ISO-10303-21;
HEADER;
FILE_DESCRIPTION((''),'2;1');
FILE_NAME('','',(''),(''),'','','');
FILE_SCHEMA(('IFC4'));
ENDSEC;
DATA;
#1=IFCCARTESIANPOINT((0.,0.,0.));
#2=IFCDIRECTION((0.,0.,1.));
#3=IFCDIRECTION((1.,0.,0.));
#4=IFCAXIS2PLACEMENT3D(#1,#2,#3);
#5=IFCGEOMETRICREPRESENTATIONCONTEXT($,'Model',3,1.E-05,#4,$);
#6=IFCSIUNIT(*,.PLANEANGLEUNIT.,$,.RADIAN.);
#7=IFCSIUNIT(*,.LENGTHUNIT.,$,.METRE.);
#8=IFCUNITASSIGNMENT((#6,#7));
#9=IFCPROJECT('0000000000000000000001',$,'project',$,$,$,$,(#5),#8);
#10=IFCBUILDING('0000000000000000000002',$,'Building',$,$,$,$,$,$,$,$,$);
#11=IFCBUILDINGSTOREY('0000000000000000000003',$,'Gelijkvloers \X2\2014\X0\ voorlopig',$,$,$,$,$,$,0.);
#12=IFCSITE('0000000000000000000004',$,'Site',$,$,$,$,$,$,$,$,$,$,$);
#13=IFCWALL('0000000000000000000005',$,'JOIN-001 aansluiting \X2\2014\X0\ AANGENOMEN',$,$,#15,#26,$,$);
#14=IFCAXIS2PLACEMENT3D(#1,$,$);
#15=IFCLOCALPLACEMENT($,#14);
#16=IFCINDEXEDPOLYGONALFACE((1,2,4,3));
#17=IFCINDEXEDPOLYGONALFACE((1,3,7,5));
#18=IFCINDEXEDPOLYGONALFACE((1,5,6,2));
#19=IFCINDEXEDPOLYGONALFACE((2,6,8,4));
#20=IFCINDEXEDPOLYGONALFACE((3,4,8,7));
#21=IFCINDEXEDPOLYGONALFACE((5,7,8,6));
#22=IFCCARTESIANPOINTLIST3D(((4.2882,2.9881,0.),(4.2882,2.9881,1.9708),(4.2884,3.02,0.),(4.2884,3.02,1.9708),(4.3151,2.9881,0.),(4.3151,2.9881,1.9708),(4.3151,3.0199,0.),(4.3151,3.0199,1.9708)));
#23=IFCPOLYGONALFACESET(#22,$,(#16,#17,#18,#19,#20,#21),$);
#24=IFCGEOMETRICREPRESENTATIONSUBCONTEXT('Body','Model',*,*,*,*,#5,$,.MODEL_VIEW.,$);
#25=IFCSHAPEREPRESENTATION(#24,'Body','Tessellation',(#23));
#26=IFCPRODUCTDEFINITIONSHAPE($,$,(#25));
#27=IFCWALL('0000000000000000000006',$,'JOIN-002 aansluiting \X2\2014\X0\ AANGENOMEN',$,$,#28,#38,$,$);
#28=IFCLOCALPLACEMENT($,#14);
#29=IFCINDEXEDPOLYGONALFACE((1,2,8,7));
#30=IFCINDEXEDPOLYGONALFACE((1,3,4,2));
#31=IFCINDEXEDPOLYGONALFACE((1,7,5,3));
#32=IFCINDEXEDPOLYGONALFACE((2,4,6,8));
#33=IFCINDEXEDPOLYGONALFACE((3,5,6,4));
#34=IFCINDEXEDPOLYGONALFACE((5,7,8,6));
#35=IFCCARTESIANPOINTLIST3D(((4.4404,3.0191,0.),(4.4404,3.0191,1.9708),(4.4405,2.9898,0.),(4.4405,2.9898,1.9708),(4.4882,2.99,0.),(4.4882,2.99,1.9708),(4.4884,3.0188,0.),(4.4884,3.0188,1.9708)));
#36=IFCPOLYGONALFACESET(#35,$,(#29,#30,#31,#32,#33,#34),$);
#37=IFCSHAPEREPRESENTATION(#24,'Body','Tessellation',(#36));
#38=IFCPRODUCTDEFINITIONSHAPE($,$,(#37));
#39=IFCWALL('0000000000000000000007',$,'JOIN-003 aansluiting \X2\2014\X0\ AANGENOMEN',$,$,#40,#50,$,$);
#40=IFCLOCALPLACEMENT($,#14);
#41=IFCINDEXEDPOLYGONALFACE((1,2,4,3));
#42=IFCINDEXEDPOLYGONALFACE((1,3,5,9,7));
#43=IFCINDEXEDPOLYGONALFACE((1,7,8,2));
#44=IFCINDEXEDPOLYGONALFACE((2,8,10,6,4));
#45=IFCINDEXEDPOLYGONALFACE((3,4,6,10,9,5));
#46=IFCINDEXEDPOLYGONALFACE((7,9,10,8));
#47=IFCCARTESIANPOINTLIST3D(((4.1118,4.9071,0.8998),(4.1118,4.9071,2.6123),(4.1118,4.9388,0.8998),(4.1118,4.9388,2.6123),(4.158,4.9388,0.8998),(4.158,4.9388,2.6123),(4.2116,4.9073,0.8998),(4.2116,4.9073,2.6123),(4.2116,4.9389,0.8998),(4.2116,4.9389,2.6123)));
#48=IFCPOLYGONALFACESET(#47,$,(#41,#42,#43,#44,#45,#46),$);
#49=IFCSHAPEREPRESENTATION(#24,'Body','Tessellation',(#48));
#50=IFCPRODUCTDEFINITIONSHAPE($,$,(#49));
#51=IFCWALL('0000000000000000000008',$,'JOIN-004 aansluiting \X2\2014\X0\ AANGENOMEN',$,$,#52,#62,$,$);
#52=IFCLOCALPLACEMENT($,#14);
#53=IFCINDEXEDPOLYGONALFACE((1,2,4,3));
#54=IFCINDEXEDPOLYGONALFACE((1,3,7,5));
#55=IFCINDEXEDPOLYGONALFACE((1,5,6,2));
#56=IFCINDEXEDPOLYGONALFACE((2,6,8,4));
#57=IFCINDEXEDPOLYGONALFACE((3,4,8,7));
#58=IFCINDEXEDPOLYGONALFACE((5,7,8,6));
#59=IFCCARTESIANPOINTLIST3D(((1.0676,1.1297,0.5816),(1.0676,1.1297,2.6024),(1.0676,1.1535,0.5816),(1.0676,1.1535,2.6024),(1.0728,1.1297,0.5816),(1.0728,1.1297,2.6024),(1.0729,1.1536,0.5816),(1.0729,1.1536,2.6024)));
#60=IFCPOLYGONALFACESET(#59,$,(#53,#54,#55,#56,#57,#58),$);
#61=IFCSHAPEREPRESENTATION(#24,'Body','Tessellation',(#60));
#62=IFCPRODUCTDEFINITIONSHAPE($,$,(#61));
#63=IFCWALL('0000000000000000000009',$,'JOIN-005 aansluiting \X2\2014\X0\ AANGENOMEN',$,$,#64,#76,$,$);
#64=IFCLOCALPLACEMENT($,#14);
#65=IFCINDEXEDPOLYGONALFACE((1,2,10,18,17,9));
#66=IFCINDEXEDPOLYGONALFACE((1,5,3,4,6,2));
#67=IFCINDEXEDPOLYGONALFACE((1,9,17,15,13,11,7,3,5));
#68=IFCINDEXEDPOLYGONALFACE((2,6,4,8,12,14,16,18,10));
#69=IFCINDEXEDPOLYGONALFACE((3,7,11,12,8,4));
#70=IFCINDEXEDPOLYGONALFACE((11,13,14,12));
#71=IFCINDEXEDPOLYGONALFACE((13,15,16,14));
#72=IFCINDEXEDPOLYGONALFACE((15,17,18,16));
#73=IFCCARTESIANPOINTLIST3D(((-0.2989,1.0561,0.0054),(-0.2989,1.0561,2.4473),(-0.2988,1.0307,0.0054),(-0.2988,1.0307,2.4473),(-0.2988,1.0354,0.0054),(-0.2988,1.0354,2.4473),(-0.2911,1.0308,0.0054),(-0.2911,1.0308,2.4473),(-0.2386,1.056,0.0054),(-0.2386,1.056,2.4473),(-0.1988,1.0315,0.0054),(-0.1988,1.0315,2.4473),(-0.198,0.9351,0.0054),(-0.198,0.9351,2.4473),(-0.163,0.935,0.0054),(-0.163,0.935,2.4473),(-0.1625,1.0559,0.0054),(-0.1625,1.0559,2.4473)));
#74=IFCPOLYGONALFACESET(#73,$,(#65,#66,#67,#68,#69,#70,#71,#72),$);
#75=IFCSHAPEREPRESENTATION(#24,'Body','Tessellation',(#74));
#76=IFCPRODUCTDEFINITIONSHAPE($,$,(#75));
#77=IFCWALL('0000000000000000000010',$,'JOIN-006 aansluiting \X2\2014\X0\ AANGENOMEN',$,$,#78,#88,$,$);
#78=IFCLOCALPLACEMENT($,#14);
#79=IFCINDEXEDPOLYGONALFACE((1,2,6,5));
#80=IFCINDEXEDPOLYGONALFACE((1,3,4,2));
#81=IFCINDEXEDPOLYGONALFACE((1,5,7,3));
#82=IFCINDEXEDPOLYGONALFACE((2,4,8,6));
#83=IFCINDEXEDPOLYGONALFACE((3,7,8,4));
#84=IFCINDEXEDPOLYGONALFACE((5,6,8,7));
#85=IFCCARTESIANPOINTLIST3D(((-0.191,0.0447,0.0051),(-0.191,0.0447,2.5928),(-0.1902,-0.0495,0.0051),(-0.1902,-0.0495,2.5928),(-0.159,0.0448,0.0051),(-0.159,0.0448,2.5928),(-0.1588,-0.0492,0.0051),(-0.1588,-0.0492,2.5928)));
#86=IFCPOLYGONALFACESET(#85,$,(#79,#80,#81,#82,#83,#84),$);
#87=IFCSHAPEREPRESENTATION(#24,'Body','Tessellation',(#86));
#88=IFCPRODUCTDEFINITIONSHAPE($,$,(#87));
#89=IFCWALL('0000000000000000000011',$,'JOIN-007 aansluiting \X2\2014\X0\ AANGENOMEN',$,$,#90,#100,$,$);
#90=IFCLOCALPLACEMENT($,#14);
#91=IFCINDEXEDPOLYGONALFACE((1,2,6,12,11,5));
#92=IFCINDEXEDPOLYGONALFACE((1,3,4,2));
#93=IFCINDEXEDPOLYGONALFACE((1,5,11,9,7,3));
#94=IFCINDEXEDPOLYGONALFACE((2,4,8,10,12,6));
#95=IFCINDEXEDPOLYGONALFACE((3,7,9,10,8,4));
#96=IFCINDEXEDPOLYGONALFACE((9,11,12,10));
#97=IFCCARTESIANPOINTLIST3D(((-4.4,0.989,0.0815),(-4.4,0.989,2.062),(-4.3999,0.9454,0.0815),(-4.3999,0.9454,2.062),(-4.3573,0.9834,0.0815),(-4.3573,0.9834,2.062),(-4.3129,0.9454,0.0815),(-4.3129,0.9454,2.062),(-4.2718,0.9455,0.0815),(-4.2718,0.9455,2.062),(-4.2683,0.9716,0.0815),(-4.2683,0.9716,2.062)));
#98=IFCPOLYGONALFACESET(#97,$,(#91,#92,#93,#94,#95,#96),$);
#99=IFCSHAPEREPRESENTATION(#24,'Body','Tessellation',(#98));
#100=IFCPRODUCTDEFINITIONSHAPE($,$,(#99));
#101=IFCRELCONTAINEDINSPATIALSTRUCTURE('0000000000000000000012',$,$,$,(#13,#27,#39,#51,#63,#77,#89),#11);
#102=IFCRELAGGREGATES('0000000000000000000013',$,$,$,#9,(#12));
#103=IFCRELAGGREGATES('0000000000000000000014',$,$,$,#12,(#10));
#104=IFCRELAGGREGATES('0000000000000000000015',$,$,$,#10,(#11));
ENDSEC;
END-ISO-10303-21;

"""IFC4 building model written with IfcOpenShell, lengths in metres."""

from ifc_helpers import new_model, si_unit, frame, origin_with_axes, place, context, subcontext, project, spatial, polyline, outline, extrude, element, save


model = new_model("IFC4")

# Units and contexts
model_context = context("Model", 3, precision=1e-05, world=origin_with_axes())
body_context = subcontext(model_context, "Body", "Model", "MODEL_VIEW")
ifc_project = project(units=[si_unit("PLANEANGLEUNIT", "RADIAN"), si_unit("LENGTHUNIT", "METRE")], contexts=[model_context])

# Site, building, storey
site = spatial("IfcSite", under=ifc_project, Name="Site")
building = spatial("IfcBuilding", under=site, Name="Building")
storey = spatial("IfcBuildingStorey", under=building, Name="Gelijkvloers — voorlopig", Elevation=0.0)

# Walls
wall_1_placement = place(None, origin_with_axes())
element("IfcWall", 1, at=wall_1_placement, inside=storey, Name="JOIN-001 aansluiting — AANGENOMEN", context=body_context, shape_type="SweptSolid", body=[
    extrude(outline(polyline([(4.2884, 3.02), (4.3151, 3.0199), (4.3151, 2.9881), (4.2657, 2.988), (4.2882, 2.9881), (4.2884, 3.02)])), origin_with_axes(), (0.0, 0.0, 1.0), 1.9708),
])
wall_2_placement = place(None, origin_with_axes())
element("IfcWall", 2, at=wall_2_placement, inside=storey, Name="JOIN-002 aansluiting — AANGENOMEN", context=body_context, shape_type="SweptSolid", body=[
    extrude(outline(polyline([(4.4405, 2.9898), (4.4404, 3.0191), (4.4884, 3.0188), (4.4882, 2.99), (4.4405, 2.9898)])), origin_with_axes(), (0.0, 0.0, 1.0), 1.9708),
])
wall_3_placement = place(None, frame((0.0, 0.0, 0.8998), z_axis=(0.0, 0.0, 1.0), x_axis=(1.0, 0.0, 0.0)))
element("IfcWall", 3, at=wall_3_placement, inside=storey, Name="JOIN-003 aansluiting — AANGENOMEN", context=body_context, shape_type="SweptSolid", body=[
    extrude(outline(polyline([(4.1118, 4.9071), (4.1118, 4.9388), (4.158, 4.9388), (4.2116, 4.9389), (4.2116, 4.9073), (4.1118, 4.9071)])), origin_with_axes(), (0.0, 0.0, 1.0), 1.7125),
])
wall_4_placement = place(None, frame((0.0, 0.0, 0.5816), z_axis=(0.0, 0.0, 1.0), x_axis=(1.0, 0.0, 0.0)))
element("IfcWall", 4, at=wall_4_placement, inside=storey, Name="JOIN-004 aansluiting — AANGENOMEN", context=body_context, shape_type="SweptSolid", body=[
    extrude(outline(polyline([(1.0676, 1.1297), (1.0676, 1.1535), (1.0729, 1.1536), (1.0728, 1.1297), (1.0676, 1.1297)])), origin_with_axes(), (0.0, 0.0, 1.0), 2.0208),
])
wall_5_placement = place(None, frame((0.0, 0.0, 0.0054), z_axis=(0.0, 0.0, 1.0), x_axis=(1.0, 0.0, 0.0)))
element("IfcWall", 5, at=wall_5_placement, inside=storey, Name="JOIN-005 aansluiting — AANGENOMEN", context=body_context, shape_type="SweptSolid", body=[
    extrude(outline(polyline([(-0.1988, 1.0315), (-0.2911, 1.0308), (-0.2988, 1.0307), (-0.2988, 1.0354), (-0.2989, 1.0561), (-0.2386, 1.056), (-0.1625, 1.0559), (-0.163, 0.935), (-0.198, 0.9351), (-0.1988, 1.0315)])), origin_with_axes(), (0.0, 0.0, 1.0), 2.442),
])
wall_6_placement = place(None, frame((0.0, 0.0, 0.0051), z_axis=(0.0, 0.0, 1.0), x_axis=(1.0, 0.0, 0.0)))
element("IfcWall", 6, at=wall_6_placement, inside=storey, Name="JOIN-006 aansluiting — AANGENOMEN", context=body_context, shape_type="SweptSolid", body=[
    extrude(outline(polyline([(-0.1588, -0.0492), (-0.1902, -0.0495), (-0.191, 0.0447), (-0.159, 0.0448), (-0.1588, -0.0492)])), origin_with_axes(), (0.0, 0.0, 1.0), 2.5878),
])
wall_7_placement = place(None, frame((0.0, 0.0, 0.0815), z_axis=(0.0, 0.0, 1.0), x_axis=(1.0, 0.0, 0.0)))
element("IfcWall", 7, at=wall_7_placement, inside=storey, Name="JOIN-007 aansluiting — AANGENOMEN", context=body_context, shape_type="SweptSolid", body=[
    extrude(outline(polyline([(-4.3129, 0.9454), (-4.3999, 0.9454), (-4.4, 0.989), (-4.3573, 0.9834), (-4.2683, 0.9716), (-4.2718, 0.9455), (-4.3129, 0.9454)])), origin_with_axes(), (0.0, 0.0, 1.0), 1.9806),
])

save(model, "model.ifc")
